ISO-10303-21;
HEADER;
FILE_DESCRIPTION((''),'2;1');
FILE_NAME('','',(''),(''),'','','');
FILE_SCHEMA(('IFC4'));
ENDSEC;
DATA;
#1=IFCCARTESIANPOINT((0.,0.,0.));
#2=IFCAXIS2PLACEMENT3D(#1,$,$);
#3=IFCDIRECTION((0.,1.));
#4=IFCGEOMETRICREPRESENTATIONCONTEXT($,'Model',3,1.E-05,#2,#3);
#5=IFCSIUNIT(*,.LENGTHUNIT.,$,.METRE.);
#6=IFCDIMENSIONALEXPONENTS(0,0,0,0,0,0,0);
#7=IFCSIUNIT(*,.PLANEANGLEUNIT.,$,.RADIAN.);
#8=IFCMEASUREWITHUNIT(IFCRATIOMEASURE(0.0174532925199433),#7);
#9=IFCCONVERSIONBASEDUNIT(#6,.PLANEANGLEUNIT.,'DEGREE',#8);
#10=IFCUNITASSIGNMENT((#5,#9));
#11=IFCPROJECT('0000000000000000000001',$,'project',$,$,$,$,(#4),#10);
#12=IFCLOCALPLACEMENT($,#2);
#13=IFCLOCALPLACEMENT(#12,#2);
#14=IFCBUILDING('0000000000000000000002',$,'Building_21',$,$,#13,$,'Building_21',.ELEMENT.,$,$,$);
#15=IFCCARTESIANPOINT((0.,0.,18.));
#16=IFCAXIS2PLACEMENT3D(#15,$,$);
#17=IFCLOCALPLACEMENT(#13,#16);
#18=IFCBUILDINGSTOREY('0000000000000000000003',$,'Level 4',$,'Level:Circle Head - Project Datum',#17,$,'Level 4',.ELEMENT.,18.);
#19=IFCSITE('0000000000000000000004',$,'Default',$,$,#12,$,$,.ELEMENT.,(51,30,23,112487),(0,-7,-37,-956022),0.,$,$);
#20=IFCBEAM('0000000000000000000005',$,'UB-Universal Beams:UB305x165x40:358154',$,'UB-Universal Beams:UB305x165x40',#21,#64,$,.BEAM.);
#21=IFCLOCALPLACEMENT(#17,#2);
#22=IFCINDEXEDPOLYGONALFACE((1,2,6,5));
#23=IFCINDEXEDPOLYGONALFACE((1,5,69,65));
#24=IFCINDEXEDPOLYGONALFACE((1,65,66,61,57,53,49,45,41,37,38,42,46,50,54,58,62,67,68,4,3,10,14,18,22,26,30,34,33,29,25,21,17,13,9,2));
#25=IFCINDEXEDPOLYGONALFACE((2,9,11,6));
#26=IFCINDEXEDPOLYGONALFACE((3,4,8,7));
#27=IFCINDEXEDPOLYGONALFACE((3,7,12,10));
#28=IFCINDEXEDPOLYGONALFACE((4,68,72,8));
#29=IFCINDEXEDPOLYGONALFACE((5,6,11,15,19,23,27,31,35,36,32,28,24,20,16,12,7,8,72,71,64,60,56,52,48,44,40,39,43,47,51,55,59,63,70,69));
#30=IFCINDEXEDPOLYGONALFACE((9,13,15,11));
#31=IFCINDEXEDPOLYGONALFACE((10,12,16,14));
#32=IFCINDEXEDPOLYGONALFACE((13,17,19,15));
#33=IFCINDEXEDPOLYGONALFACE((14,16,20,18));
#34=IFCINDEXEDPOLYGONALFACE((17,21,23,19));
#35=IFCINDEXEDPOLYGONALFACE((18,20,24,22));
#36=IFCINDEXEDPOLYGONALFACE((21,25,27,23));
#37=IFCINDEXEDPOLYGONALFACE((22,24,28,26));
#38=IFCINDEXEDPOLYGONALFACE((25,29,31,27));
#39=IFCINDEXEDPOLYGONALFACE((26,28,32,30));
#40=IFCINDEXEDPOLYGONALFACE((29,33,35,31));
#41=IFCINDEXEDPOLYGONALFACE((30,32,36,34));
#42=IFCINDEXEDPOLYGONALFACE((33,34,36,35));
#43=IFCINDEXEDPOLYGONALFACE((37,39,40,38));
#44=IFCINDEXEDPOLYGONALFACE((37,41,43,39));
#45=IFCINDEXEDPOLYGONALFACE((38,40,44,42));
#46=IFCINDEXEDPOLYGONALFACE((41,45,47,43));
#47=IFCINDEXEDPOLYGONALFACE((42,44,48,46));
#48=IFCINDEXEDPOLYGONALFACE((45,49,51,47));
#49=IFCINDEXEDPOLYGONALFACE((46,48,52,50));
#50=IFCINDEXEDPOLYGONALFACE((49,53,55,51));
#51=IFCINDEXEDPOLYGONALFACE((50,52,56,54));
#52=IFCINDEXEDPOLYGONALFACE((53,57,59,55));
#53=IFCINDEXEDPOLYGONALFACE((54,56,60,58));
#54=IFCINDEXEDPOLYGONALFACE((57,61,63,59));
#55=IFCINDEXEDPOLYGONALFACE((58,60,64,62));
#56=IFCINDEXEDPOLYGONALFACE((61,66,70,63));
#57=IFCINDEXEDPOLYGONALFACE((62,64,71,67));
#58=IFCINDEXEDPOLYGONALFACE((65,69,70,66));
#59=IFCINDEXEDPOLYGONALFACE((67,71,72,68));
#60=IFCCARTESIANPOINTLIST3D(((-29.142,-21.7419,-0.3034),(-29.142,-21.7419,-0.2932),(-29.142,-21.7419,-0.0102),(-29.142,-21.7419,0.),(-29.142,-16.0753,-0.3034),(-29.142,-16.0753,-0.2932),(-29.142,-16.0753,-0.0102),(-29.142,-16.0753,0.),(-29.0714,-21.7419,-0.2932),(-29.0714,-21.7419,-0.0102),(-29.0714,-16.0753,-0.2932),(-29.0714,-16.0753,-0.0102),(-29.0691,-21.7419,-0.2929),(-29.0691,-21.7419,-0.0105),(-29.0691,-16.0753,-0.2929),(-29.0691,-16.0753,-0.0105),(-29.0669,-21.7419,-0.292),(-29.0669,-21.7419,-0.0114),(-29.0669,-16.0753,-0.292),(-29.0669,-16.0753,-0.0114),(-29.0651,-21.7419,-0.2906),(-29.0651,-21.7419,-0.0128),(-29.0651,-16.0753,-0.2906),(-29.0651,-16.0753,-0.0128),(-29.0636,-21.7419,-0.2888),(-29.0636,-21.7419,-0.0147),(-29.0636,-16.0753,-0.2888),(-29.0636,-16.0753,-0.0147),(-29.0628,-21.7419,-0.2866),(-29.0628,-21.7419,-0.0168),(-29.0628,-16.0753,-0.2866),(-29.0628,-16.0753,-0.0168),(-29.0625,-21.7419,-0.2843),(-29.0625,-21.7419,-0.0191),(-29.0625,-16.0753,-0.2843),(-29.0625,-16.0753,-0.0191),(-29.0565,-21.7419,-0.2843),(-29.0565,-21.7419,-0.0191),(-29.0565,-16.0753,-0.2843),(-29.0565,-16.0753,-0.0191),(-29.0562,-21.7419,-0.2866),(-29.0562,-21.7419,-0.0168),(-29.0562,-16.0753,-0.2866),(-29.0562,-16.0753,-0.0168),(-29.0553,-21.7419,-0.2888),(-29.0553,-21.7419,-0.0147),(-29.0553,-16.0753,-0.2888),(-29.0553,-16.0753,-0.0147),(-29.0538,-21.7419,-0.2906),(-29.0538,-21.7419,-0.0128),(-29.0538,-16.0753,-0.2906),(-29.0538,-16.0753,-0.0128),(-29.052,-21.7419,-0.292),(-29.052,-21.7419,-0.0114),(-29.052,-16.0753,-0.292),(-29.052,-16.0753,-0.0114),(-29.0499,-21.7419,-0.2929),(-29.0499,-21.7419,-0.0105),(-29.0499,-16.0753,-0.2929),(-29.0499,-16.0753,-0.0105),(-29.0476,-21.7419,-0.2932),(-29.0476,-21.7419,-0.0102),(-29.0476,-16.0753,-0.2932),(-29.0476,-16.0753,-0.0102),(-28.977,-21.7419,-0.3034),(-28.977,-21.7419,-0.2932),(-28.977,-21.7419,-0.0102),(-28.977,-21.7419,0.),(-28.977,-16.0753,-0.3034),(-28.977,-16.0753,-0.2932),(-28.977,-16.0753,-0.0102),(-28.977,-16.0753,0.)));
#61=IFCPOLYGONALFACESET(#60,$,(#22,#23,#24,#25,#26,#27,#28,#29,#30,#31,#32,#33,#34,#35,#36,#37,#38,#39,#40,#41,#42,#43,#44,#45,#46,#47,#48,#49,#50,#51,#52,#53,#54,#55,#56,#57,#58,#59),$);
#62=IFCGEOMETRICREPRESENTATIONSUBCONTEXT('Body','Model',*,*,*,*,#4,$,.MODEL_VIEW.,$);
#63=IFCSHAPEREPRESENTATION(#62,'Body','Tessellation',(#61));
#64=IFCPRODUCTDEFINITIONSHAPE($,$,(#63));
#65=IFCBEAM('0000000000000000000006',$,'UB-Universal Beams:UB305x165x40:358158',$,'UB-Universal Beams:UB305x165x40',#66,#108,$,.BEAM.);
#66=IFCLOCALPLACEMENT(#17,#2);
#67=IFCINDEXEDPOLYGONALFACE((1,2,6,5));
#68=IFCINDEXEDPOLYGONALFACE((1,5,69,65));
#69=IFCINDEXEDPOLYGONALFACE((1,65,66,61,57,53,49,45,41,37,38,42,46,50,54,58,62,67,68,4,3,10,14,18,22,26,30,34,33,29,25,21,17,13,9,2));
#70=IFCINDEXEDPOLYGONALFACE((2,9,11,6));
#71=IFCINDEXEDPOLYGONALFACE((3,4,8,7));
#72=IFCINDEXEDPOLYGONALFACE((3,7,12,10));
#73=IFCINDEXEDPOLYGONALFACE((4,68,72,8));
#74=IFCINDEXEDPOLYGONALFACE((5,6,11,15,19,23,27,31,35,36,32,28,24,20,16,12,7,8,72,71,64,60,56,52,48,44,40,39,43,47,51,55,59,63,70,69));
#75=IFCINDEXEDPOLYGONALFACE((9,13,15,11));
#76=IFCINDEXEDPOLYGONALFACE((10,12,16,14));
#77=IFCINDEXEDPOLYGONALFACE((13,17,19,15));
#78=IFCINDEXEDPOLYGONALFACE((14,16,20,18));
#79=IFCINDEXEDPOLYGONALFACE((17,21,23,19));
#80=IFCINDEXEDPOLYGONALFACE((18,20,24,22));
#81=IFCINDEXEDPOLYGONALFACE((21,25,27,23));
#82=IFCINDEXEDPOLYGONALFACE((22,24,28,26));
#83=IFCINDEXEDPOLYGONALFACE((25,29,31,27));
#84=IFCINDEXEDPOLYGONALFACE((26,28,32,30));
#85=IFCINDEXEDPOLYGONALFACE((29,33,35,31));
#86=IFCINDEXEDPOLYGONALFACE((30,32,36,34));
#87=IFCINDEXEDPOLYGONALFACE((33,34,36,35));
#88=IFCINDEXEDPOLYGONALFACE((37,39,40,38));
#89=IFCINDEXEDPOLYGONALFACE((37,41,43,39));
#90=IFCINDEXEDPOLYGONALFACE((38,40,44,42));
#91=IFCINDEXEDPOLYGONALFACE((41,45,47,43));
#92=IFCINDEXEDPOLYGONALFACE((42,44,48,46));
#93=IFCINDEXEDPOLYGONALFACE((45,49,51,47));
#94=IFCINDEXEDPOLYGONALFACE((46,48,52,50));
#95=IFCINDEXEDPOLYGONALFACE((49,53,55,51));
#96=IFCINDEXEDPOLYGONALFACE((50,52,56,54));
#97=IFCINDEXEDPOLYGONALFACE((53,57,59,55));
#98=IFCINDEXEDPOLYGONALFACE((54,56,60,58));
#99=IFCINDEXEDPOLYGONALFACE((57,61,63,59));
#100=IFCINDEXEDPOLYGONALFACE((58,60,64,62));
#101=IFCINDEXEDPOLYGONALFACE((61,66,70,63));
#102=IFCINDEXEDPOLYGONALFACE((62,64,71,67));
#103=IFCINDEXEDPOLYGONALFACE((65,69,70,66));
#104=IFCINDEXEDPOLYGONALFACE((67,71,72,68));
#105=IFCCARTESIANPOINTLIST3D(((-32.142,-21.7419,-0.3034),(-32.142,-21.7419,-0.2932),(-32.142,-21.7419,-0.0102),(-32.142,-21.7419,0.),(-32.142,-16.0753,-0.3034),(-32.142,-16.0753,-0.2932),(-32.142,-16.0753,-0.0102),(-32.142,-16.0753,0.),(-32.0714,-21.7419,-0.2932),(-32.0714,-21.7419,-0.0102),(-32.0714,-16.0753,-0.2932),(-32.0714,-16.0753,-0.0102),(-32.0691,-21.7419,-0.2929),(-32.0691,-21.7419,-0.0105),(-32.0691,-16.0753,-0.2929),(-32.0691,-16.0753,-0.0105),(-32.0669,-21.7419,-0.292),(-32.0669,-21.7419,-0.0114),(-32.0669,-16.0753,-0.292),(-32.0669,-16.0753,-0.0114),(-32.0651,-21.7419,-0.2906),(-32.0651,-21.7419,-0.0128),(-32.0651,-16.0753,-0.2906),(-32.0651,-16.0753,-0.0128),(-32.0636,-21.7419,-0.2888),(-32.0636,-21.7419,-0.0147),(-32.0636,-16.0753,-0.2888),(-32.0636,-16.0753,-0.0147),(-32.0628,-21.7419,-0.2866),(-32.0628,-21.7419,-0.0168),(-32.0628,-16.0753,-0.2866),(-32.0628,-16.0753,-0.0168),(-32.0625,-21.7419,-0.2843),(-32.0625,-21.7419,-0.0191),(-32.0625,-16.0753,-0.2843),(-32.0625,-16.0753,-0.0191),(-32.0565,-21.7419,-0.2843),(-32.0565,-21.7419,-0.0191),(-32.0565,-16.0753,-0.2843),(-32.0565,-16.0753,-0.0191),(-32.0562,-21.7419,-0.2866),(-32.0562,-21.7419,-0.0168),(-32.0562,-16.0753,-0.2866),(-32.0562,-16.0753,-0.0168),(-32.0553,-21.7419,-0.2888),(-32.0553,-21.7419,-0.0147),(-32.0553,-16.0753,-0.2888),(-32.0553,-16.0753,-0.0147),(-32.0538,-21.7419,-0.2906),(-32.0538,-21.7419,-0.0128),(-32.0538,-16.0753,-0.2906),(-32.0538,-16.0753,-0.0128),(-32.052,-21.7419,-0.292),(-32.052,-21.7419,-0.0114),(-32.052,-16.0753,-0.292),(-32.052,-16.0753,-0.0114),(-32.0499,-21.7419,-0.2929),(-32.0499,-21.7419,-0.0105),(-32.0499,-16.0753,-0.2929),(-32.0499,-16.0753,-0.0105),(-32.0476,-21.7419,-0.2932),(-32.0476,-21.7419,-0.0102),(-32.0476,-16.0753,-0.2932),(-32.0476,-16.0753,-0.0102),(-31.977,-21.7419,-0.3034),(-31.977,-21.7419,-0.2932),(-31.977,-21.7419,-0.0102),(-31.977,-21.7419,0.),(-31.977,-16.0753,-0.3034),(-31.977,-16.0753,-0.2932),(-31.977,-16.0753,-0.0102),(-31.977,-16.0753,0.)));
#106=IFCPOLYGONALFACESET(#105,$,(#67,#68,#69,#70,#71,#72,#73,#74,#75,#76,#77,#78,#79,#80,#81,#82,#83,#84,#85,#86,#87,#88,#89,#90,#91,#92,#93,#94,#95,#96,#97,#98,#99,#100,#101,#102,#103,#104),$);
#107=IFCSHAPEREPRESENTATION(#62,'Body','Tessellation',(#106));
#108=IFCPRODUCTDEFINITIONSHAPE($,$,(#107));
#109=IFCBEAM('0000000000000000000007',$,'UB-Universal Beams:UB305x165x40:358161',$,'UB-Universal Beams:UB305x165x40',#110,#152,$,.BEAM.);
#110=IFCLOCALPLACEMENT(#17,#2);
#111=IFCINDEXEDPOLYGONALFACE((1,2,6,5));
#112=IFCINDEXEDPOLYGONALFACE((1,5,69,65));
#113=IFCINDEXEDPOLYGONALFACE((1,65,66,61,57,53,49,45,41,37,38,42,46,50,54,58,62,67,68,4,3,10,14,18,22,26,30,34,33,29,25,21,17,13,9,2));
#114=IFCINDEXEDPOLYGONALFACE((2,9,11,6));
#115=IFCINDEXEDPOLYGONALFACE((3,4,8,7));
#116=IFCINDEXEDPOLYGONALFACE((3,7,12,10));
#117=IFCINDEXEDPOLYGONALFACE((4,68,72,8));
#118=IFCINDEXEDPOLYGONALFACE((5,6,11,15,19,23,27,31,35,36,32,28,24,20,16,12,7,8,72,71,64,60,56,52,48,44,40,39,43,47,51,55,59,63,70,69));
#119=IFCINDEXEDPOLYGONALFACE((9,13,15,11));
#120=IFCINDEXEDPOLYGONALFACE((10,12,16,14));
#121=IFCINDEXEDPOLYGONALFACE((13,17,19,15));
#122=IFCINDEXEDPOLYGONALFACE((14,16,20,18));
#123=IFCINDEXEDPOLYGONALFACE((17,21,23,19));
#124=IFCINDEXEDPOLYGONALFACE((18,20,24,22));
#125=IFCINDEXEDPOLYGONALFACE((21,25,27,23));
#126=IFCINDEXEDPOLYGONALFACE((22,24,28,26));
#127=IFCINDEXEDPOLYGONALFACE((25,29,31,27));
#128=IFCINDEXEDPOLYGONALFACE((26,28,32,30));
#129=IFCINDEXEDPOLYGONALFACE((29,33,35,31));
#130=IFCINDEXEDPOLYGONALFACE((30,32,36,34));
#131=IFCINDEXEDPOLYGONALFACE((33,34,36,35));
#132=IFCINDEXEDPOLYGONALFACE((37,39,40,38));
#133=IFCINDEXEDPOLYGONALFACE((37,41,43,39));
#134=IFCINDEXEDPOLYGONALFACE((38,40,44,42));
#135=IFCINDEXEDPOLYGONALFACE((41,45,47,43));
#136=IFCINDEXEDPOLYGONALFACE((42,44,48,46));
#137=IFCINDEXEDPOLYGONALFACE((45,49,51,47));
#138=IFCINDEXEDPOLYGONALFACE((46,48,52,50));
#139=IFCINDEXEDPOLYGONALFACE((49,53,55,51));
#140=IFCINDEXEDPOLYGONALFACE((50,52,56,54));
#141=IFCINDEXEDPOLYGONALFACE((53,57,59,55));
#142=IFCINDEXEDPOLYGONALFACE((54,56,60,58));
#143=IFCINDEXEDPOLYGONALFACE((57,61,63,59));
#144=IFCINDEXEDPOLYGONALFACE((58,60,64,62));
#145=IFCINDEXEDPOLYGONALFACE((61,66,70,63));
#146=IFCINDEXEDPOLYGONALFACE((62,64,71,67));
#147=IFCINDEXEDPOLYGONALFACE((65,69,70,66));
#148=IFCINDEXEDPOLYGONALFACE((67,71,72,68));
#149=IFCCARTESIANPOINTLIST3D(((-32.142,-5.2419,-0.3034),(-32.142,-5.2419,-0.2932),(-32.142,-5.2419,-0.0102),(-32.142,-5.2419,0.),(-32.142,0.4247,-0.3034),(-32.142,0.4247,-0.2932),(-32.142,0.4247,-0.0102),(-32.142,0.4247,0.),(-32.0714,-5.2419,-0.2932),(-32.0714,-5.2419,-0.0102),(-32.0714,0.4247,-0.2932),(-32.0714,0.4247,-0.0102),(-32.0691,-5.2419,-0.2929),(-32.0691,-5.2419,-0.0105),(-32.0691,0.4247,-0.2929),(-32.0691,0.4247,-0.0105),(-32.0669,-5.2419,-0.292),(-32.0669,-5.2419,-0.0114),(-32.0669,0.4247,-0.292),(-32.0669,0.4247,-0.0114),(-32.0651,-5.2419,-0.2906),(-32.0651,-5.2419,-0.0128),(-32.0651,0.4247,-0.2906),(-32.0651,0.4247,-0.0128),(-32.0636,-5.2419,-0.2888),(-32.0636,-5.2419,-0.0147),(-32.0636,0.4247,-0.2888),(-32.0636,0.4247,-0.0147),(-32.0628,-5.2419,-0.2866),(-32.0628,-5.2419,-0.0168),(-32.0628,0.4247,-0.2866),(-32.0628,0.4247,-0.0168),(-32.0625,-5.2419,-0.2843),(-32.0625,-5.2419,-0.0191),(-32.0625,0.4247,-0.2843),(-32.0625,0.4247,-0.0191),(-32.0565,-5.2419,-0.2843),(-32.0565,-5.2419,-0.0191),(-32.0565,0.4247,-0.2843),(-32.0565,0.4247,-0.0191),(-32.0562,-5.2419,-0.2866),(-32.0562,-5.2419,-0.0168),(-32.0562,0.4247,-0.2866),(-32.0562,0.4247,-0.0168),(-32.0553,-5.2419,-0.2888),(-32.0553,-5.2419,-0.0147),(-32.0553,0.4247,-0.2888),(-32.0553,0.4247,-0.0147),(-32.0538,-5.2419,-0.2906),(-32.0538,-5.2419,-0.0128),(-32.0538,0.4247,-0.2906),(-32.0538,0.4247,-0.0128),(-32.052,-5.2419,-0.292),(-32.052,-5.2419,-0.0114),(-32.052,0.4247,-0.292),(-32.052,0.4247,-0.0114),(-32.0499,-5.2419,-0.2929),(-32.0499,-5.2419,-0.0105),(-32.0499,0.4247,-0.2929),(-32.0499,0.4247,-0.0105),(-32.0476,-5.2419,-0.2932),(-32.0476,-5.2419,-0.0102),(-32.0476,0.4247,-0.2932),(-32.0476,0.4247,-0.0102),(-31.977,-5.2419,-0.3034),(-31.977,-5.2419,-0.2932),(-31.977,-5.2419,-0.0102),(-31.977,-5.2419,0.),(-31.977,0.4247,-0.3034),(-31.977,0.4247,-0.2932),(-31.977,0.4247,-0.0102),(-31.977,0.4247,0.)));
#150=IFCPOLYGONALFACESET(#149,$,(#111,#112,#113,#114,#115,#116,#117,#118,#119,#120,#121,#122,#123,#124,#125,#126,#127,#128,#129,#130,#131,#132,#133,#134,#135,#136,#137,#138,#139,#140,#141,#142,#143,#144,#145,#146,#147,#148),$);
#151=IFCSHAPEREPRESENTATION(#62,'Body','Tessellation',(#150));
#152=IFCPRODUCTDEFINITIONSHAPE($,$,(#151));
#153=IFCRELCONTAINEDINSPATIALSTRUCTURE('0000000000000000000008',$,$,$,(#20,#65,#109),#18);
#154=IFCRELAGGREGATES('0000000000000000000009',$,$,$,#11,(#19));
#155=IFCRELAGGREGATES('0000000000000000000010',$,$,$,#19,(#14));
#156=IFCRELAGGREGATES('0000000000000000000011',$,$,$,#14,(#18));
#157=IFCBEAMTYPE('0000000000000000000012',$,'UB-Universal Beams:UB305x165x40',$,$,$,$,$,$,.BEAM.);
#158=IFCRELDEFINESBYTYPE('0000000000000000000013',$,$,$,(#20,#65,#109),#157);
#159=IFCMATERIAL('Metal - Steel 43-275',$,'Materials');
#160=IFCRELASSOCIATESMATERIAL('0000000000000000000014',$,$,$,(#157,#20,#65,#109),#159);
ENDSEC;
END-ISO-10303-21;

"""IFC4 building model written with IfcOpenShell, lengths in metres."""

from ifc_helpers import new_model, entity, si_unit, converted_unit, direction, frame, frame_2d, origin, place, context, subcontext, project, spatial, polyline, circle_curve, parameter, trimmed, segment, composite_curve, i_section, outline, extrude, source, transform, mapped, material, material_profile, profile_set, profile_usage, type_object, type_shapes, element, save


model = new_model("IFC4")

# Units and contexts
model_context = context("Model", 3, precision=1e-05, world=origin(), true_north=direction((0.0, 1.0)))
body_context = subcontext(model_context, "Body", "Model", "MODEL_VIEW")
ifc_project = project(units=[si_unit("LENGTHUNIT", "METRE"), converted_unit("PLANEANGLEUNIT", "DEGREE", entity("IfcRatioMeasure", 0.0174532925199433), si_unit("PLANEANGLEUNIT", "RADIAN"), dimensions=[0, 0, 0, 0, 0, 0, 0])], contexts=[model_context])

# Site, building, storey
site_placement = place(None, origin())
site = spatial("IfcSite", under=ifc_project, at=site_placement, Name="Default", CompositionType="ELEMENT", RefLatitude=(51, 30, 23, 112487), RefLongitude=(0, -7, -37, -956022), RefElevation=0.0)
building_placement = place(site_placement, origin())
building = spatial("IfcBuilding", under=site, at=building_placement, Name="Building_21", LongName="Building_21", CompositionType="ELEMENT")
storey_placement = place(building_placement, frame((0.0, 0.0, 18.0)))
storey = spatial("IfcBuildingStorey", under=building, at=storey_placement, Name="Level 4", ObjectType="Level:Circle Head - Project Datum", LongName="Level 4", CompositionType="ELEMENT", Elevation=18.0)

# Beams
ifc_material_1 = material(Name="Metal - Steel 43-275", Category="Materials")
ifc_material_profile_1 = material_profile(ifc_material_1, outline(composite_curve([segment(polyline([(0.0119, -0.1415, 0.0), (0.0825, -0.1415, 0.0)]), True, "CONTINUOUS"), segment(polyline([(0.0825, -0.1415, 0.0), (0.0825, -0.1517, 0.0)]), True, "CONTINUOUS"), segment(polyline([(0.0825, -0.1517, 0.0), (-0.0825, -0.1517, 0.0)]), True, "CONTINUOUS"), segment(polyline([(-0.0825, -0.1517, 0.0), (-0.0825, -0.1415, 0.0)]), True, "CONTINUOUS"), segment(polyline([(-0.0825, -0.1415, 0.0), (-0.0119, -0.1415, 0.0)]), True, "CONTINUOUS"), segment(trimmed(circle_curve(frame((-0.0119, -0.1326, 0.0), z_axis=(0.0, 0.0, 1.0), x_axis=(-1.0, 0.0, 0.0)), 0.0089), [parameter(90.0)], [parameter(180.0)], True, "PARAMETER"), True, "CONTINUOUS"), segment(polyline([(-0.003, -0.1326, 0.0), (-0.003, 0.1326, 0.0)]), True, "CONTINUOUS"), segment(trimmed(circle_curve(frame((-0.0119, 0.1326, 0.0), z_axis=(0.0, 0.0, 1.0), x_axis=(-1.0, 0.0, 0.0)), 0.0089), [parameter(180.0)], [parameter(270.0)], True, "PARAMETER"), True, "CONTINUOUS"), segment(polyline([(-0.0119, 0.1415, 0.0), (-0.0825, 0.1415, 0.0)]), True, "CONTINUOUS"), segment(polyline([(-0.0825, 0.1415, 0.0), (-0.0825, 0.1517, 0.0)]), True, "CONTINUOUS"), segment(polyline([(-0.0825, 0.1517, 0.0), (0.0825, 0.1517, 0.0)]), True, "CONTINUOUS"), segment(polyline([(0.0825, 0.1517, 0.0), (0.0825, 0.1415, 0.0)]), True, "CONTINUOUS"), segment(polyline([(0.0825, 0.1415, 0.0), (0.0119, 0.1415, 0.0)]), True, "CONTINUOUS"), segment(trimmed(circle_curve(frame((0.0119, 0.1326, 0.0), z_axis=(0.0, 0.0, 1.0), x_axis=(-1.0, 0.0, 0.0)), 0.0089), [parameter(270.0)], [parameter(0.0)], True, "PARAMETER"), True, "CONTINUOUS"), segment(polyline([(0.003, 0.1326, 0.0), (0.003, -0.1326, 0.0)]), True, "CONTINUOUS"), segment(trimmed(circle_curve(frame((0.0119, -0.1326, 0.0), z_axis=(0.0, 0.0, 1.0), x_axis=(-1.0, 0.0, 0.0)), 0.0089), [parameter(0.0)], [parameter(90.0)], True, "PARAMETER"), True, "CONTINUOUS")], self_intersect=False), kind="CURVE"), Name="UB305x165x40")
ifc_material_profile_2 = material_profile(ifc_material_1, outline(composite_curve([segment(polyline([(-1.3346, 0.0825, -0.1415), (-1.3346, 0.0825, -0.1517)]), True, "CONTINUOUS"), segment(polyline([(-1.3346, 0.0825, -0.1517), (-1.3346, -0.0825, -0.1517)]), True, "CONTINUOUS"), segment(polyline([(-1.3346, -0.0825, -0.1517), (-1.3346, -0.0825, -0.1415)]), True, "CONTINUOUS"), segment(polyline([(-1.3346, -0.0825, -0.1415), (-1.3346, -0.003, -0.1415)]), True, "CONTINUOUS"), segment(polyline([(-1.3346, -0.003, -0.1415), (-1.3346, -0.003, 0.1415)]), True, "CONTINUOUS"), segment(polyline([(-1.3346, -0.003, 0.1415), (-1.3346, -0.0825, 0.1415)]), True, "CONTINUOUS"), segment(polyline([(-1.3346, -0.0825, 0.1415), (-1.3346, -0.0825, 0.1517)]), True, "CONTINUOUS"), segment(polyline([(-1.3346, -0.0825, 0.1517), (-1.3346, 0.0825, 0.1517)]), True, "CONTINUOUS"), segment(polyline([(-1.3346, 0.0825, 0.1517), (-1.3346, 0.0825, 0.1415)]), True, "CONTINUOUS"), segment(polyline([(-1.3346, 0.0825, 0.1415), (-1.3346, 0.003, 0.1415)]), True, "CONTINUOUS"), segment(polyline([(-1.3346, 0.003, 0.1415), (-1.3346, 0.003, -0.1415)]), True, "CONTINUOUS"), segment(polyline([(-1.3346, 0.003, -0.1415), (-1.3346, 0.0825, -0.1415)]), True, "CONTINUOUS")], self_intersect=False), kind="CURVE"), Name="UB305x165x40")
ifc_profile_set = profile_set([ifc_material_profile_1, ifc_material_profile_2], Name="UB305x165x40")
beam_type_1 = type_object("IfcBeamType", Name="UB-Universal Beams:UB305x165x40", PredefinedType="BEAM", material=ifc_profile_set)
shared_shape_1 = source(origin(), body_context, "Body", "SweptSolid", [
    extrude(i_section(OverallWidth=0.165, OverallDepth=0.3034, WebThickness=0.006, FlangeThickness=0.0102, FilletRadius=0.0089, at=frame_2d((0.0, 0.0), x_axis=(0.0, 1.0))), frame((-2.8333, 0.0, 0.0), z_axis=(1.0, 0.0, 0.0), x_axis=(0.0, 0.0, -1.0)), (0.0, 0.0, 1.0), 5.6666),
])
type_shapes(beam_type_1, [shared_shape_1])
ifc_profile_usage_1 = profile_usage(ifc_profile_set, cardinal=8)
beam_1_placement = place(storey_placement, frame((-29.0595, -18.9086, -0.1517), z_axis=(0.0, 0.0, 1.0), x_axis=(0.0, 1.0, 0.0)))
element("IfcBeam", 1, at=beam_1_placement, inside=storey, type_object=beam_type_1, material=ifc_profile_usage_1, Name="UB-Universal Beams:UB305x165x40:358154", ObjectType="UB-Universal Beams:UB305x165x40", PredefinedType="BEAM", context=body_context, shape_type="MappedRepresentation", body=[
    mapped(shared_shape_1, transform((0.0, 0.0, 0.0), scale=1.0)),
])
ifc_profile_usage_2 = profile_usage(ifc_profile_set, cardinal=8)
beam_2_placement = place(storey_placement, frame((-32.0595, -18.9086, -0.1517), z_axis=(0.0, 0.0, 1.0), x_axis=(0.0, -1.0, 0.0)))
element("IfcBeam", 2, at=beam_2_placement, inside=storey, type_object=beam_type_1, material=ifc_profile_usage_2, Name="UB-Universal Beams:UB305x165x40:358158", ObjectType="UB-Universal Beams:UB305x165x40", PredefinedType="BEAM", context=body_context, shape_type="MappedRepresentation", body=[
    mapped(shared_shape_1, transform((0.0, 0.0, 0.0), scale=1.0)),
])
ifc_profile_usage_3 = profile_usage(ifc_profile_set, cardinal=8)
beam_3_placement = place(storey_placement, frame((-32.0595, -2.4086, -0.1517), z_axis=(0.0, 0.0, 1.0), x_axis=(0.0, -1.0, 0.0)))
element("IfcBeam", 3, at=beam_3_placement, inside=storey, type_object=beam_type_1, material=ifc_profile_usage_3, Name="UB-Universal Beams:UB305x165x40:358161", ObjectType="UB-Universal Beams:UB305x165x40", PredefinedType="BEAM", context=body_context, shape_type="MappedRepresentation", body=[
    mapped(shared_shape_1, transform((0.0, 0.0, 0.0), scale=1.0)),
])

save(model, "model.ifc")
